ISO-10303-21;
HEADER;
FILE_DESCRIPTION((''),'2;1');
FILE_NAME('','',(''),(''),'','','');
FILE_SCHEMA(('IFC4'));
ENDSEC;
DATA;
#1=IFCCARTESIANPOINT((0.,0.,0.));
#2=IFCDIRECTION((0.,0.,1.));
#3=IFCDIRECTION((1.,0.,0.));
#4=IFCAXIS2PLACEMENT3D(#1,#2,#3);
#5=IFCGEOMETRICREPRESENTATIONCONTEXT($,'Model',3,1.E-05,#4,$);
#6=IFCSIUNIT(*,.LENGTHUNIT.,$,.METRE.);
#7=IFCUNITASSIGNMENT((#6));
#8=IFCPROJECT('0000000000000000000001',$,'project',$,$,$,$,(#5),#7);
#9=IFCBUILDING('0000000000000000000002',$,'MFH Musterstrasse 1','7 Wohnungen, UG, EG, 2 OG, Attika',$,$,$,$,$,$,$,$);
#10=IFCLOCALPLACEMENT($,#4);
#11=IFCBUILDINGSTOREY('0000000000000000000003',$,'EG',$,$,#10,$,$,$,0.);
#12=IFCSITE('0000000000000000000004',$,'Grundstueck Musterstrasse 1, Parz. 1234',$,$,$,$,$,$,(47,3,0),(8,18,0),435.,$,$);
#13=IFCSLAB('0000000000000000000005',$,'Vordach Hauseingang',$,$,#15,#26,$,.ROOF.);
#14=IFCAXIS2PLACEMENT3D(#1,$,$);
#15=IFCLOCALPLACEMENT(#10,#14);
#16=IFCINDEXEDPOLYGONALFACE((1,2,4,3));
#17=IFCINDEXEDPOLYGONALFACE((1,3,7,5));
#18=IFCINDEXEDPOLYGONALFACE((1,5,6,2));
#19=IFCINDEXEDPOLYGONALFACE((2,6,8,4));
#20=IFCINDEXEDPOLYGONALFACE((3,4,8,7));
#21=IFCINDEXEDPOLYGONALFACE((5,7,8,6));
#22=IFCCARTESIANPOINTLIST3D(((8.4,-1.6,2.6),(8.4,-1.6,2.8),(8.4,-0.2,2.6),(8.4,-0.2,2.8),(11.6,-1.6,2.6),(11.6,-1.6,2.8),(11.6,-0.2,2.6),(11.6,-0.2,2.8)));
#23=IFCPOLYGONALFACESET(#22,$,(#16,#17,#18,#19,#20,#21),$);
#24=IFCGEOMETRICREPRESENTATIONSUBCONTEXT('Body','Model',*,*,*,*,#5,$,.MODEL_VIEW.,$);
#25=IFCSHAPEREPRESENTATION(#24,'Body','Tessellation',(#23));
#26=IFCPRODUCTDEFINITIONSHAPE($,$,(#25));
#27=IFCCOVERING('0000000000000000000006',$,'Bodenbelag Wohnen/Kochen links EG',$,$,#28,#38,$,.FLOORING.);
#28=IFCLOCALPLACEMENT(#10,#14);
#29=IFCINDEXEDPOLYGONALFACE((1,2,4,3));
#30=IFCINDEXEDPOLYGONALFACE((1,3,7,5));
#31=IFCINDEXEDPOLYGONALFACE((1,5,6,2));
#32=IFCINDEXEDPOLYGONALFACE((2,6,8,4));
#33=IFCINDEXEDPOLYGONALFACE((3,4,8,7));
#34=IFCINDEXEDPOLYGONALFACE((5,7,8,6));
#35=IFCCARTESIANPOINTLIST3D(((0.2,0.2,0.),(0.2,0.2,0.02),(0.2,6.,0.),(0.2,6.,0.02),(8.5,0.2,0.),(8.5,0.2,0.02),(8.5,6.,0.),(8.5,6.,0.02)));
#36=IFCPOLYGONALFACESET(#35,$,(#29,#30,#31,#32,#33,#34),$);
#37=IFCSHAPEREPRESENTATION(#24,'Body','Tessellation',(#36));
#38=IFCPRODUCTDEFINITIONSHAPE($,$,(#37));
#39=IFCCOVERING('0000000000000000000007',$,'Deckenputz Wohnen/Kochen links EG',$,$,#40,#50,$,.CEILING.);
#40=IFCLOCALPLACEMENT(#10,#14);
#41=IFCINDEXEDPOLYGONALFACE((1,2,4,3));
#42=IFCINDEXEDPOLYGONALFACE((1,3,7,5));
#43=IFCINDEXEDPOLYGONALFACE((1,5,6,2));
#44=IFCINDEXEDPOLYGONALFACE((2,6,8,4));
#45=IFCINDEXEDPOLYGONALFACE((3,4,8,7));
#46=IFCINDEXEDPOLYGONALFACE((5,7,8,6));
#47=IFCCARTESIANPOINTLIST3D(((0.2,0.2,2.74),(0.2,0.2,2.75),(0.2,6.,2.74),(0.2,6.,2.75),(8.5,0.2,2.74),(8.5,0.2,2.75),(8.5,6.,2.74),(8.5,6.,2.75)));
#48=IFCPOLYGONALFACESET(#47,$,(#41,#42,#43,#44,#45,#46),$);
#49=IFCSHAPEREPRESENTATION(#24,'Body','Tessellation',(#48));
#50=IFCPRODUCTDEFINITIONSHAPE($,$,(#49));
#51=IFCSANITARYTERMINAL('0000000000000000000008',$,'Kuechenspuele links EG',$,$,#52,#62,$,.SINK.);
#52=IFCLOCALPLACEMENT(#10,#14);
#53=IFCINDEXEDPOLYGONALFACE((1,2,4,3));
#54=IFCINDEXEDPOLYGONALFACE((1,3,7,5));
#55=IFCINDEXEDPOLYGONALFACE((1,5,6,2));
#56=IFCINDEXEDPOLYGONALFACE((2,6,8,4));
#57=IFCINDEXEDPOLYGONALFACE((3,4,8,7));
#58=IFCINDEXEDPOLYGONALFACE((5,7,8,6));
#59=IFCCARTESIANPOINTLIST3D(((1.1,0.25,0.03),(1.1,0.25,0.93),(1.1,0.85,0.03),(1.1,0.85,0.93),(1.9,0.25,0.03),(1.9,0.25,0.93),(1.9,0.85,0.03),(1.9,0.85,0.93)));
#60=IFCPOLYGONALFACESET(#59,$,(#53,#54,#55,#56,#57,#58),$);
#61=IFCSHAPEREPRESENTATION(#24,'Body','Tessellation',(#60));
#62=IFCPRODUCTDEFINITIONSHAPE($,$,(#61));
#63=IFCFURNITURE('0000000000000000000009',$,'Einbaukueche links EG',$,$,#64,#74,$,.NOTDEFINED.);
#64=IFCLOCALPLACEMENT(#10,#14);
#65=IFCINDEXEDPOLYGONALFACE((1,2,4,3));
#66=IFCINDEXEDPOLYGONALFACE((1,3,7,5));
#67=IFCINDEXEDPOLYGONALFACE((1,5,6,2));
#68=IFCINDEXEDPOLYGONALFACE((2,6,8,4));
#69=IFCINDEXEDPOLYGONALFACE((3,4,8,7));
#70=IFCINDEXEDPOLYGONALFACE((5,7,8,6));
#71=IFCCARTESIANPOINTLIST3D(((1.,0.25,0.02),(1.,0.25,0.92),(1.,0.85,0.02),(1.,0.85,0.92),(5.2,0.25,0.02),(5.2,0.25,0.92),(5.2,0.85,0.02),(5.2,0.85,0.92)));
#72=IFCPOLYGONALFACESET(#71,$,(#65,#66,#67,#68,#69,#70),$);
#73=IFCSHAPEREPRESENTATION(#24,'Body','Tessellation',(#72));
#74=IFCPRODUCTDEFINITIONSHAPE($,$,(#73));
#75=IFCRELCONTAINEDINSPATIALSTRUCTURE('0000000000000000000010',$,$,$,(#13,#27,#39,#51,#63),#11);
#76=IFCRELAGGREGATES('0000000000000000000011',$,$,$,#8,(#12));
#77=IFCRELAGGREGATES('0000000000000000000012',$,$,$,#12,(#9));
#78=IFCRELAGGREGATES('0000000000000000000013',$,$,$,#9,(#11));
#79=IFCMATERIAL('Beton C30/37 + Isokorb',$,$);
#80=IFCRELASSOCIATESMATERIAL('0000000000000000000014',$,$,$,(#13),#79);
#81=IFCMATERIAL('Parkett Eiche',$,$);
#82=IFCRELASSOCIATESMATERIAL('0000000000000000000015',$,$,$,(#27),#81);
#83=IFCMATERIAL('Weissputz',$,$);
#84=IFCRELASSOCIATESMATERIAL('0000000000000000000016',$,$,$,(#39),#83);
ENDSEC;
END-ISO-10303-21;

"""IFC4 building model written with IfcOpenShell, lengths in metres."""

from ifc_helpers import new_model, si_unit, frame, frame_2d, origin_with_axes, place, context, subcontext, project, spatial, polyline, rectangle, outline, extrude, material, element, save


model = new_model("IFC4")

# Units and contexts
model_context = context("Model", 3, precision=1e-05, world=origin_with_axes())
body_context = subcontext(model_context, "Body", "Model", "MODEL_VIEW")
ifc_project = project(units=[si_unit("LENGTHUNIT", "METRE")], contexts=[model_context])

# Site, building, storey
site = spatial("IfcSite", under=ifc_project, Name="Grundstueck Musterstrasse 1, Parz. 1234", RefLatitude=(47, 3, 0), RefLongitude=(8, 18, 0), RefElevation=435.0)
building = spatial("IfcBuilding", under=site, Name="MFH Musterstrasse 1", Description="7 Wohnungen, UG, EG, 2 OG, Attika")
storey_placement = place(None, origin_with_axes())
storey = spatial("IfcBuildingStorey", under=building, at=storey_placement, Name="EG", Elevation=0.0)

# Slab
ifc_material_1 = material(Name="Beton C30/37 + Isokorb")
slab_placement = place(storey_placement, frame((0.0, 0.0, 2.6), z_axis=(0.0, 0.0, 1.0), x_axis=(1.0, 0.0, 0.0)))
element("IfcSlab", 1, at=slab_placement, inside=storey, material=ifc_material_1, Name="Vordach Hauseingang", PredefinedType="ROOF", context=body_context, shape_type="SweptSolid", body=[
    extrude(outline(polyline([(8.4, -1.6), (11.6, -1.6), (11.6, -0.2), (8.4, -0.2), (8.4, -1.6)])), origin_with_axes(), (0.0, 0.0, 1.0), 0.2),
])

# Coverings
ifc_material_2 = material(Name="Parkett Eiche")
covering_1_placement = place(storey_placement, frame((0.2, 0.2, 0.0), z_axis=(0.0, 0.0, 1.0), x_axis=(1.0, 0.0, 0.0)))
element("IfcCovering", 2, at=covering_1_placement, inside=storey, material=ifc_material_2, Name="Bodenbelag Wohnen/Kochen links EG", PredefinedType="FLOORING", context=body_context, shape_type="SweptSolid", body=[
    extrude(rectangle(XDim=8.3, YDim=5.8, at=frame_2d((4.15, 2.9))), origin_with_axes(), (0.0, 0.0, 1.0), 0.02),
])
ifc_material_3 = material(Name="Weissputz")
covering_2_placement = place(storey_placement, frame((0.2, 0.2, 2.74), z_axis=(0.0, 0.0, 1.0), x_axis=(1.0, 0.0, 0.0)))
element("IfcCovering", 3, at=covering_2_placement, inside=storey, material=ifc_material_3, Name="Deckenputz Wohnen/Kochen links EG", PredefinedType="CEILING", context=body_context, shape_type="SweptSolid", body=[
    extrude(rectangle(XDim=8.3, YDim=5.8, at=frame_2d((4.15, 2.9))), origin_with_axes(), (0.0, 0.0, 1.0), 0.01),
])

# Sanitary terminal
sanitary_terminal_placement = place(storey_placement, frame((1.1, 0.25, 0.03), z_axis=(0.0, 0.0, 1.0), x_axis=(1.0, 0.0, 0.0)))
element("IfcSanitaryTerminal", 4, at=sanitary_terminal_placement, inside=storey, Name="Kuechenspuele links EG", PredefinedType="SINK", context=body_context, shape_type="SweptSolid", body=[
    extrude(rectangle(XDim=0.8, YDim=0.6, at=frame_2d((0.4, 0.3))), origin_with_axes(), (0.0, 0.0, 1.0), 0.9),
])

# Furniture
furniture_placement = place(storey_placement, frame((1.0, 0.25, 0.02), z_axis=(0.0, 0.0, 1.0), x_axis=(1.0, 0.0, 0.0)))
element("IfcFurniture", 5, at=furniture_placement, inside=storey, Name="Einbaukueche links EG", PredefinedType="NOTDEFINED", context=body_context, shape_type="SweptSolid", body=[
    extrude(rectangle(XDim=4.2, YDim=0.6, at=frame_2d((2.1, 0.3))), origin_with_axes(), (0.0, 0.0, 1.0), 0.9),
])

save(model, "model.ifc")
